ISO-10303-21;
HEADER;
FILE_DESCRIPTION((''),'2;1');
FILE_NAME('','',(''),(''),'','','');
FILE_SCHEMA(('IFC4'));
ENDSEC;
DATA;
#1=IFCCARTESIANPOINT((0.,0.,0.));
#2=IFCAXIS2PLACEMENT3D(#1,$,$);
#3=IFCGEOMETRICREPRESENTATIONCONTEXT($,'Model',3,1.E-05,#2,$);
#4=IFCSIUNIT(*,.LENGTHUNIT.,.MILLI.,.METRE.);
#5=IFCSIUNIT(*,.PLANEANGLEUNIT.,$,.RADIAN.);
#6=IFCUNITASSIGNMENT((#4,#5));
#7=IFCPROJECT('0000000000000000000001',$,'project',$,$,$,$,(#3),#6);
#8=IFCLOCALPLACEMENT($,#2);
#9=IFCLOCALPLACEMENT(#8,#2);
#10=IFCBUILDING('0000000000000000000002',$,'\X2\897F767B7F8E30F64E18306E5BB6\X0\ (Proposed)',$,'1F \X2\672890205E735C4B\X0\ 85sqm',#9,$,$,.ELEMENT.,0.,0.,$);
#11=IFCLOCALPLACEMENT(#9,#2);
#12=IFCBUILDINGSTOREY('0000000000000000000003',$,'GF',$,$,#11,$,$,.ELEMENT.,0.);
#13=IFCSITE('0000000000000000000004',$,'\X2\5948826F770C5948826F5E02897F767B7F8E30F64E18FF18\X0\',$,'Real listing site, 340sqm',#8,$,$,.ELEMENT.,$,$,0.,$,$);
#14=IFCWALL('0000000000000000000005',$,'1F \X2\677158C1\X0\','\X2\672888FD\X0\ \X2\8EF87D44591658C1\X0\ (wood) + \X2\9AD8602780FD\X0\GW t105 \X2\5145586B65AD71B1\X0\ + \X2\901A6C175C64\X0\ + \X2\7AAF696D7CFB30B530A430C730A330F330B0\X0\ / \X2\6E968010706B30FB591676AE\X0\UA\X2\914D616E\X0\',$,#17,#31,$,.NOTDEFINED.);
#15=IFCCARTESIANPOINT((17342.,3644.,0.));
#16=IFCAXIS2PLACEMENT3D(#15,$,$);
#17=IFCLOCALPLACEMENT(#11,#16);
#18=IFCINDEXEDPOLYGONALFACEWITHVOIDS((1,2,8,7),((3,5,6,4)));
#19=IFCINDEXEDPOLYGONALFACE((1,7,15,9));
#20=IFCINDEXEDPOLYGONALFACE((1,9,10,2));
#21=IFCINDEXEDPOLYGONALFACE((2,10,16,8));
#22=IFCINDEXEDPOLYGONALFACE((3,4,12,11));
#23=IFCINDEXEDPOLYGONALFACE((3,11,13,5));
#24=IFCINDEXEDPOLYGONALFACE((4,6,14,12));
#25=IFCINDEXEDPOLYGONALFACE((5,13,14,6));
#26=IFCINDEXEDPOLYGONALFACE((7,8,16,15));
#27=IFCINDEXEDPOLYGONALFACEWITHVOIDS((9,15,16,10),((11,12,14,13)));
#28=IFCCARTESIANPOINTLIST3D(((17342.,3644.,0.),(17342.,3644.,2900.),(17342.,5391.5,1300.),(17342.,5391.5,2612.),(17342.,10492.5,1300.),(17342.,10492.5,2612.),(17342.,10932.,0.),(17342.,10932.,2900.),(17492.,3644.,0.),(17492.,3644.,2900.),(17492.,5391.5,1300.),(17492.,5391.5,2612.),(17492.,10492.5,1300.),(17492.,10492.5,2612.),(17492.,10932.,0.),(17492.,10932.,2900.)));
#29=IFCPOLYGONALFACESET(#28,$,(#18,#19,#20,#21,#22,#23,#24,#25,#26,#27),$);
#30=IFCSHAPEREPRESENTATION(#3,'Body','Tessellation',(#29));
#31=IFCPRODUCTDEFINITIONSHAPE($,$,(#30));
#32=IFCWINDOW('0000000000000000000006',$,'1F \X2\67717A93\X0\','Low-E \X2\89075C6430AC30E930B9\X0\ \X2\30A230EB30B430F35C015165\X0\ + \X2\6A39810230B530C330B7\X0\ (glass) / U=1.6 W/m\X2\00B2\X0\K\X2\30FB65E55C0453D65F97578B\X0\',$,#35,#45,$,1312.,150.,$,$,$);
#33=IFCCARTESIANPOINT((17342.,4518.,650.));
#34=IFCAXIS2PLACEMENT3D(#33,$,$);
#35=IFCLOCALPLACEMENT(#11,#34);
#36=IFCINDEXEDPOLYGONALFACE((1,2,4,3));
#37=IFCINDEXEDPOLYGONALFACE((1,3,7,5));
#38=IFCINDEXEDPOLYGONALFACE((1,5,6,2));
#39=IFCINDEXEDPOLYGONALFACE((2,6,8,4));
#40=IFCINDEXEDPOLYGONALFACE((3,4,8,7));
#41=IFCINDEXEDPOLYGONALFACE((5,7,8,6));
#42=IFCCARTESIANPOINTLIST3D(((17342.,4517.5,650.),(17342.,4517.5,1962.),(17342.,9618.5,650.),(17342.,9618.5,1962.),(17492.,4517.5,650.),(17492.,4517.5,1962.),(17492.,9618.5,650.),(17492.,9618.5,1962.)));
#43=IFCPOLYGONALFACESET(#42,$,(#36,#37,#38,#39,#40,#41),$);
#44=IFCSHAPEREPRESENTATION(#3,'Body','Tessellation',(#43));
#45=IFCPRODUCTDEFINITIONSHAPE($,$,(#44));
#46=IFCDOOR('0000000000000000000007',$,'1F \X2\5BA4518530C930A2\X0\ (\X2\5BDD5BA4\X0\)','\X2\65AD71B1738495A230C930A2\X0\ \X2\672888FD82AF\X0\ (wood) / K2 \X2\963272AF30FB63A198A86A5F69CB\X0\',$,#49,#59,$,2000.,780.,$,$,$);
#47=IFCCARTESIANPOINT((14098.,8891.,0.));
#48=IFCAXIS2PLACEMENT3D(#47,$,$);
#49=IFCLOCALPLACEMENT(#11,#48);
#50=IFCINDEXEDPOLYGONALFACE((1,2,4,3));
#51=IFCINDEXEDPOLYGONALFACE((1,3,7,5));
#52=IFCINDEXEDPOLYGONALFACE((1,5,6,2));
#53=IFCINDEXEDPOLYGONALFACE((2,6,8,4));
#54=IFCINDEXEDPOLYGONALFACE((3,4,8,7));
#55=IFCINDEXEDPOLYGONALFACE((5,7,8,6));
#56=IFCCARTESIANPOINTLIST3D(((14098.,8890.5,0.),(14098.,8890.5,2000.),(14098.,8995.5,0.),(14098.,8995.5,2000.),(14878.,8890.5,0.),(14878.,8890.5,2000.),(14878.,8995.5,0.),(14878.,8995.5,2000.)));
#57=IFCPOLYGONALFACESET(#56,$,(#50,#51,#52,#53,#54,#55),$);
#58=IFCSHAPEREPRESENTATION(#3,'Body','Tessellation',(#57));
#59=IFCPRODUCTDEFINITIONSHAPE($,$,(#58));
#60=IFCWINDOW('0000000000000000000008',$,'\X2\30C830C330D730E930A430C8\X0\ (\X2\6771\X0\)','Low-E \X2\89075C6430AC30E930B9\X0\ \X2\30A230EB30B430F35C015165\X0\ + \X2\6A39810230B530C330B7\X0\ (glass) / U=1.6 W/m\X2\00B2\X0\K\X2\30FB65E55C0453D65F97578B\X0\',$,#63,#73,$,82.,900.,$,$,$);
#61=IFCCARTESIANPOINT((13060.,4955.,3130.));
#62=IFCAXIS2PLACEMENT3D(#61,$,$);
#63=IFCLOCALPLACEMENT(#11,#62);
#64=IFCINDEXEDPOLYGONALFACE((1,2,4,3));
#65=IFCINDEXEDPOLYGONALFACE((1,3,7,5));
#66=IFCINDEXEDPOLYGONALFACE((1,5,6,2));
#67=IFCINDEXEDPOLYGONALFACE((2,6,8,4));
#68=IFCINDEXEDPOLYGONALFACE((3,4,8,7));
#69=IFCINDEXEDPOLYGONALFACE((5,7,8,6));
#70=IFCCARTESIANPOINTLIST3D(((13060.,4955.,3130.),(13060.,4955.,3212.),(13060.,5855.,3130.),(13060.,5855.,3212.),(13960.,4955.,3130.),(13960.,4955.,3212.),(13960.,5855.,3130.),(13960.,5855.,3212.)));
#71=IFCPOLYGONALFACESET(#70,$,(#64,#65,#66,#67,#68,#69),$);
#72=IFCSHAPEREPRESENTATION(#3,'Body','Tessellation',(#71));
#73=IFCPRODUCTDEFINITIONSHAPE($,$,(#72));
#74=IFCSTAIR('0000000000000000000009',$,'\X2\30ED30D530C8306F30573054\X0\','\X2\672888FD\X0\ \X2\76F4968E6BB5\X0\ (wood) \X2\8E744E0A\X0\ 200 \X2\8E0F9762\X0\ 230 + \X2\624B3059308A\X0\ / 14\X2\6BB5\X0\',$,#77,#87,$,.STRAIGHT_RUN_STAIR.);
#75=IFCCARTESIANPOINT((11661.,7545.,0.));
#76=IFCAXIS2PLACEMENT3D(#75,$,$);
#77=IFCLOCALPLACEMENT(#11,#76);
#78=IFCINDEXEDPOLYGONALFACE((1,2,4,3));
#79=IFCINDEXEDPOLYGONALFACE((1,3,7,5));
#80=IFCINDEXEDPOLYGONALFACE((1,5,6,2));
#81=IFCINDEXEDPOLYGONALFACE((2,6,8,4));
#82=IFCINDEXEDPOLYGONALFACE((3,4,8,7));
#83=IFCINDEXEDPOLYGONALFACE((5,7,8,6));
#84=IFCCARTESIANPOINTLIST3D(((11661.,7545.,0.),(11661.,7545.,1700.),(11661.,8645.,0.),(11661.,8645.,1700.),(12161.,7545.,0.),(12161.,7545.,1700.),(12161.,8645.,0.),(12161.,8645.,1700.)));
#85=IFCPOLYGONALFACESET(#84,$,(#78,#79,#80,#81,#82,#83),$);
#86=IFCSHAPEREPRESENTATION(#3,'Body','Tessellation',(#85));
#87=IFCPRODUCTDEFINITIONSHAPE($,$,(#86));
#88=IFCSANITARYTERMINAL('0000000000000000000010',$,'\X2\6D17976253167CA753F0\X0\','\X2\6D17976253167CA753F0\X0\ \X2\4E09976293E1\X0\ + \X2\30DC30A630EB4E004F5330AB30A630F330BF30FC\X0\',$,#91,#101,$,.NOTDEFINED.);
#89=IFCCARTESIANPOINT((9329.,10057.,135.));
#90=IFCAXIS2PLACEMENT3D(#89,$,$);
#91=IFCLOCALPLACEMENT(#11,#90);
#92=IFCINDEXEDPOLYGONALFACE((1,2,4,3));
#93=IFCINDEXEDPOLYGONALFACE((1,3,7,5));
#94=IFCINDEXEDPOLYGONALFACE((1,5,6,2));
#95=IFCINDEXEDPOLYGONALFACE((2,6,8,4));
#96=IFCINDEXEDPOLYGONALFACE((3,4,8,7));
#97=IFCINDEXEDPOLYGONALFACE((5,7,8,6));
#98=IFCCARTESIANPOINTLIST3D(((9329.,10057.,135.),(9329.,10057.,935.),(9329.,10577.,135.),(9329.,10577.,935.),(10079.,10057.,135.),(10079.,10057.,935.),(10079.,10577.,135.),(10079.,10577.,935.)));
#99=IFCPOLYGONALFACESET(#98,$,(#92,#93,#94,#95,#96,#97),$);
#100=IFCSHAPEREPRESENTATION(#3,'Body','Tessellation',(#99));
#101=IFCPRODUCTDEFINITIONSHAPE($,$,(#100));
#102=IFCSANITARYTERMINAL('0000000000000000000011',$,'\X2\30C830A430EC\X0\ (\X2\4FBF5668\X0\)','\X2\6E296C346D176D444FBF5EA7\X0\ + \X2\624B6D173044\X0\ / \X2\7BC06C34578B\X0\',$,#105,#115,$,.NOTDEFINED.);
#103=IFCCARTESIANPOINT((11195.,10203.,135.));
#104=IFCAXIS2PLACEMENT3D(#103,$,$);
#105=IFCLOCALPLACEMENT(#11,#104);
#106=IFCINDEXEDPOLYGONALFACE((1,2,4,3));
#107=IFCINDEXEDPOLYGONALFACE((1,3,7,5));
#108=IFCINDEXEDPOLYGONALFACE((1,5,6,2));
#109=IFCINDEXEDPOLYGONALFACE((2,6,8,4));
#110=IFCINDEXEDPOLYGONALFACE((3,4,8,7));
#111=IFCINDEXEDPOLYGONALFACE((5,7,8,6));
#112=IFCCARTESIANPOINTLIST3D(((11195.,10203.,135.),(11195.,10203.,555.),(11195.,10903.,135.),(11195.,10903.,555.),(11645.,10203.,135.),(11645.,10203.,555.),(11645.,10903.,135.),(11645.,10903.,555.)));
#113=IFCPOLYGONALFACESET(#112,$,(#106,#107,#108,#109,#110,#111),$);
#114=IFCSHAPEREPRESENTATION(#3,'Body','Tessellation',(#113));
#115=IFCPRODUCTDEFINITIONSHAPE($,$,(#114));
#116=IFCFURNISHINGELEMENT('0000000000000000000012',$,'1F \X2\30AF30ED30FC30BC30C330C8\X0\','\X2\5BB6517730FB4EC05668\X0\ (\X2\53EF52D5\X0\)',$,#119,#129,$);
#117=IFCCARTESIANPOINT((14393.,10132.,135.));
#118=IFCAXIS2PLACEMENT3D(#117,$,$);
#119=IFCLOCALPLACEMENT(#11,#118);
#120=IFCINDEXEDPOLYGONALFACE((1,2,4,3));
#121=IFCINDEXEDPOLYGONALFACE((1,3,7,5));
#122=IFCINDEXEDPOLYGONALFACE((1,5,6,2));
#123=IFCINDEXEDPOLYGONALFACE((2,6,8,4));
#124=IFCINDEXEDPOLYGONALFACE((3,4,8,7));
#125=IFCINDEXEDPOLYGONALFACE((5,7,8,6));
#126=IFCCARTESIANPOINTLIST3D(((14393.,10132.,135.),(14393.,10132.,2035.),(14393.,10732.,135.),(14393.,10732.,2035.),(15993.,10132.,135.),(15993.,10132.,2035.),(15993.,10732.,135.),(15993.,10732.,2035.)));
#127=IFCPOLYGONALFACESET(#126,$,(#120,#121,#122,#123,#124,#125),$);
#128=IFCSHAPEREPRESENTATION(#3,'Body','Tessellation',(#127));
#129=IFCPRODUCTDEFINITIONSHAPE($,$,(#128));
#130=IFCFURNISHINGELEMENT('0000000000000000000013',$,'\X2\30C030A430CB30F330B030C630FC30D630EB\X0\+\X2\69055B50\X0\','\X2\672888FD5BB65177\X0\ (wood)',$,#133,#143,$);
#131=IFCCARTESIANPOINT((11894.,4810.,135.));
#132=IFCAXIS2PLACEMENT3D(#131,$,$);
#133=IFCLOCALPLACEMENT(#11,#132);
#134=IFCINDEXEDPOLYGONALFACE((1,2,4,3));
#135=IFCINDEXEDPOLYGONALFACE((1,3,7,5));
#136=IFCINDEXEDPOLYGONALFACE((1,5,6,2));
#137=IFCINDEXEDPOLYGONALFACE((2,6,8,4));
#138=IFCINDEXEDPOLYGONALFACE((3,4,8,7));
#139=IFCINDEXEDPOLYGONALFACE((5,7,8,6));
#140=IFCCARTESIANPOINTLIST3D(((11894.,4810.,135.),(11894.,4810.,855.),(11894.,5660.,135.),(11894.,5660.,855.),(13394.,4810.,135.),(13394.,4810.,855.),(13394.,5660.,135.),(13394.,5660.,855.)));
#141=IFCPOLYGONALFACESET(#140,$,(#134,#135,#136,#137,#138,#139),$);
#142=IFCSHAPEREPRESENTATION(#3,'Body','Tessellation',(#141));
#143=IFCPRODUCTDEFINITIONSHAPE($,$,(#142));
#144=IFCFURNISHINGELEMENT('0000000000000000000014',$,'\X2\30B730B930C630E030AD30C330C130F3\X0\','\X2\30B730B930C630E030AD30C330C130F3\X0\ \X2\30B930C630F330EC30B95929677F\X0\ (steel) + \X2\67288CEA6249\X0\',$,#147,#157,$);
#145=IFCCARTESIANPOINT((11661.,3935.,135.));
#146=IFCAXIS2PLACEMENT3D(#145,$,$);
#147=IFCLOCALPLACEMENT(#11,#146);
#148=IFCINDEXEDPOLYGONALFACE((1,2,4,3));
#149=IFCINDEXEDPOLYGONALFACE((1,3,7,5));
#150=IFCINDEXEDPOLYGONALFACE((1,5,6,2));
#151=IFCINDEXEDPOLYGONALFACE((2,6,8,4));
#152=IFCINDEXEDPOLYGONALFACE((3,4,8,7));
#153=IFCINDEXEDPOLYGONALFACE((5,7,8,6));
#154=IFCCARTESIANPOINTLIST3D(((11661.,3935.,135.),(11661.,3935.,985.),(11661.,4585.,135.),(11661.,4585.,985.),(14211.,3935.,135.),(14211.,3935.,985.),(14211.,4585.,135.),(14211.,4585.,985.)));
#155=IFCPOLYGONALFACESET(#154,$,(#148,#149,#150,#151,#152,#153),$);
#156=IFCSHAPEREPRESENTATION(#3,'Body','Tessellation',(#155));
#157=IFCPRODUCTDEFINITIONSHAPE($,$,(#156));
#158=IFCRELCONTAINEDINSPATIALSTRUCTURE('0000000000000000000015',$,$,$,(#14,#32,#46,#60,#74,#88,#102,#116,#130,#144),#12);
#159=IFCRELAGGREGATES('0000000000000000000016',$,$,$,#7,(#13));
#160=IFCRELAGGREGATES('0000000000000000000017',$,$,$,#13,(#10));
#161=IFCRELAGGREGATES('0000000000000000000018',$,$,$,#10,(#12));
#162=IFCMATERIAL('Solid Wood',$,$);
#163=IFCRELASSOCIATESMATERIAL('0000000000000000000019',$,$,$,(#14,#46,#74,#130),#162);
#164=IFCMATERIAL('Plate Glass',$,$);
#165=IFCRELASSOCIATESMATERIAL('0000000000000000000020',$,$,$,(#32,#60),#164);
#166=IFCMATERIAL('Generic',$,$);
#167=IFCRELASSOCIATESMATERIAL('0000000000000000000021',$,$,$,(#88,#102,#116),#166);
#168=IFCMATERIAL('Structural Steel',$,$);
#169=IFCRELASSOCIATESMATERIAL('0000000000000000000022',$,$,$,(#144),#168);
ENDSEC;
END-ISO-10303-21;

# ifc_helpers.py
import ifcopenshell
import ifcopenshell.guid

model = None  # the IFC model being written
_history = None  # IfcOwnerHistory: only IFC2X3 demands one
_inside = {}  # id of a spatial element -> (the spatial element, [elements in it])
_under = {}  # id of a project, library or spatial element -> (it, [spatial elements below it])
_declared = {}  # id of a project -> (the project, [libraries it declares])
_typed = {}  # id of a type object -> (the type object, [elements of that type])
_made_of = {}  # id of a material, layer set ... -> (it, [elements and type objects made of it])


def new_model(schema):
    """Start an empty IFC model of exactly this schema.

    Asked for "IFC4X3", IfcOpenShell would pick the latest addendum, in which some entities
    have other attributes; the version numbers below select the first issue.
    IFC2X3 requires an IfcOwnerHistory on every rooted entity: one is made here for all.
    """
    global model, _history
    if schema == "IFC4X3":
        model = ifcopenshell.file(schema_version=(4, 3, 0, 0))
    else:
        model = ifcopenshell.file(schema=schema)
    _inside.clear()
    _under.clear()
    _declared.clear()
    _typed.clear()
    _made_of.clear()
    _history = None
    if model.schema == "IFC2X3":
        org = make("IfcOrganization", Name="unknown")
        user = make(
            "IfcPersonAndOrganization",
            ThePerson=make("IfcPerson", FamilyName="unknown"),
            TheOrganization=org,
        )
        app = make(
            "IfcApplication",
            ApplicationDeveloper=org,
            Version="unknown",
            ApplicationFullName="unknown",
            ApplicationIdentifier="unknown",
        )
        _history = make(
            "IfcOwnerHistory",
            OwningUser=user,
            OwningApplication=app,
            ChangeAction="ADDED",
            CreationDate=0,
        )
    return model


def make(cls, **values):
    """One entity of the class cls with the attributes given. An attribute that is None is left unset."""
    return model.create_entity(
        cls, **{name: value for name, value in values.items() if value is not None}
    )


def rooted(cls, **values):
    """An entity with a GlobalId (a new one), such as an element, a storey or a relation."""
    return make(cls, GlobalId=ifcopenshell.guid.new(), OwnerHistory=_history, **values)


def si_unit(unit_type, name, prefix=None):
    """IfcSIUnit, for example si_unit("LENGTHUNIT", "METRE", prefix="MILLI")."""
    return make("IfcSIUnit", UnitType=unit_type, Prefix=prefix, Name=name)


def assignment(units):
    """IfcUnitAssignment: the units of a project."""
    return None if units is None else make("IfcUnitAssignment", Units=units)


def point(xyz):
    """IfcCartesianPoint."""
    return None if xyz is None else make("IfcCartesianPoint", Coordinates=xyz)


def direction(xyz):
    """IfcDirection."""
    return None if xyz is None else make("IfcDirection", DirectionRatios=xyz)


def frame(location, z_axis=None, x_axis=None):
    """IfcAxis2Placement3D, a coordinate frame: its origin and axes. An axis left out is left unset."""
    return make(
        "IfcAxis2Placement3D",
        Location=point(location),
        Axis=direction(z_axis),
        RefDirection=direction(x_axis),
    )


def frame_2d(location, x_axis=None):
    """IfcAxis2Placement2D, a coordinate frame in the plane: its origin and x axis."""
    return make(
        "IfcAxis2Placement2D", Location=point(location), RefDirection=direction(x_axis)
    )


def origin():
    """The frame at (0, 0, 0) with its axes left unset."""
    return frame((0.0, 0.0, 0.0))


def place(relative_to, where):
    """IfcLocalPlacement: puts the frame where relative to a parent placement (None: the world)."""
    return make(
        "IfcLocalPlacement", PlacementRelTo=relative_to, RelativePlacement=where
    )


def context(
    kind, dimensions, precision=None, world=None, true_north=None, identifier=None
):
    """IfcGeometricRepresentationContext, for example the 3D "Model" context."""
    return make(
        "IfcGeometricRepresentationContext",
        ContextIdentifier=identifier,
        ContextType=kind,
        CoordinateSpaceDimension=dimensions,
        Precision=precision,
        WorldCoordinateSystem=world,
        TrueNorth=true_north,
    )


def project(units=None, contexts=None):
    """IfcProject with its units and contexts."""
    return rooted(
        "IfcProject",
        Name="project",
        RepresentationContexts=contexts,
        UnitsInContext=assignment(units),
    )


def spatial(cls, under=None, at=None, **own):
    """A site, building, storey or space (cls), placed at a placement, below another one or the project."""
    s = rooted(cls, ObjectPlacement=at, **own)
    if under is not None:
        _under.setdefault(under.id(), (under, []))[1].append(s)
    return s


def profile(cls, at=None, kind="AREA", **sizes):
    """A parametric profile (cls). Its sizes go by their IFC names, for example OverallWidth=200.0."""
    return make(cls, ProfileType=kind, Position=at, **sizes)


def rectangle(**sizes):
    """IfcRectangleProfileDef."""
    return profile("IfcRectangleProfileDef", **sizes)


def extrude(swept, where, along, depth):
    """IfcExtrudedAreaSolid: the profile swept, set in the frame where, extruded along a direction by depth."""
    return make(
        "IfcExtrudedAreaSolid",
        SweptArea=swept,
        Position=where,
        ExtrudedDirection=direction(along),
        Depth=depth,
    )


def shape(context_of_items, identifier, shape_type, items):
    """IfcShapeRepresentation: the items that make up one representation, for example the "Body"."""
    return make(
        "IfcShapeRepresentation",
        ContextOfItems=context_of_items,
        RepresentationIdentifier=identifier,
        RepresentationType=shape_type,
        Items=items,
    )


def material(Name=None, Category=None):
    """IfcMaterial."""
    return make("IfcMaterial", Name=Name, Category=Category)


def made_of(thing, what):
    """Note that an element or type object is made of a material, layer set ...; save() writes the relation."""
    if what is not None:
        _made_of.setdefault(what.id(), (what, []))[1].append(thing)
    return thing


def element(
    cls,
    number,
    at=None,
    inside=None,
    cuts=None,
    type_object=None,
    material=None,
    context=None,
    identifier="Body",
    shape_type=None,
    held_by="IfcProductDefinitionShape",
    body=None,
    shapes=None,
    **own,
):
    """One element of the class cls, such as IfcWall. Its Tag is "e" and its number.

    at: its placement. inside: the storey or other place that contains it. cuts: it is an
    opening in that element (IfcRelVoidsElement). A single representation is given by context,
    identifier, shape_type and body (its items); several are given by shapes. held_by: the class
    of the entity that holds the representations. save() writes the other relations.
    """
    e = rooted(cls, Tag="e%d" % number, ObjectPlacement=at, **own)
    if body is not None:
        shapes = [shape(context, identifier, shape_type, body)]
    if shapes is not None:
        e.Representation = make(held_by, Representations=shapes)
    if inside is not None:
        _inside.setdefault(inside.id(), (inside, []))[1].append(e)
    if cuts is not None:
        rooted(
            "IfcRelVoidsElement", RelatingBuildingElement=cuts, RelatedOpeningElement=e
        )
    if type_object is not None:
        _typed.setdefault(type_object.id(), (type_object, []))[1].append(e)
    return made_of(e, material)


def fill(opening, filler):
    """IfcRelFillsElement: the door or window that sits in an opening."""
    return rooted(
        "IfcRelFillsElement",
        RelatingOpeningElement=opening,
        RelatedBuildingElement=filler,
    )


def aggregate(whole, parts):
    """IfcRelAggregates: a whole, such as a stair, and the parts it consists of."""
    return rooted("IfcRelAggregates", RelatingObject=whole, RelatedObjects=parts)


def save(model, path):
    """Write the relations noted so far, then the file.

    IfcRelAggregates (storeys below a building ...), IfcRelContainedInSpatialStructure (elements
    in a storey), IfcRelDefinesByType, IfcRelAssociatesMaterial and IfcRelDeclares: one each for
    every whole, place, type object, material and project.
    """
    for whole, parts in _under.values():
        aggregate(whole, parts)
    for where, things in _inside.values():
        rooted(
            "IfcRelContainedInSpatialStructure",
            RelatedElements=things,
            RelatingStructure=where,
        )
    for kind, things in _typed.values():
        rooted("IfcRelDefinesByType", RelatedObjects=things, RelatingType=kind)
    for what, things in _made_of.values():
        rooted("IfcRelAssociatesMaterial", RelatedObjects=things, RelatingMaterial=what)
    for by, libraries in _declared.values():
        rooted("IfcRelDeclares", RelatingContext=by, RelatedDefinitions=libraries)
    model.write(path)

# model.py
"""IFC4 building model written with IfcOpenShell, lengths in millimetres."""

from ifc_helpers import new_model, si_unit, frame, frame_2d, origin, place, context, project, spatial, rectangle, extrude, material, element, fill, save


model = new_model("IFC4")

# Units and contexts
model_context = context("Model", 3, precision=1e-05, world=origin())
ifc_project = project(units=[si_unit("LENGTHUNIT", "METRE", prefix="MILLI"), si_unit("PLANEANGLEUNIT", "RADIAN")], contexts=[model_context])

# Site, building, storey
site_placement = place(None, origin())
site = spatial("IfcSite", under=ifc_project, at=site_placement, Name="奈良県奈良市西登美ヶ丘８", ObjectType="Real listing site, 340sqm", CompositionType="ELEMENT", RefElevation=0.0)
building_placement = place(site_placement, origin())
building = spatial("IfcBuilding", under=site, at=building_placement, Name="西登美ヶ丘の家 (Proposed)", ObjectType="1F 木造平屋 85sqm", CompositionType="ELEMENT", ElevationOfRefHeight=0.0, ElevationOfTerrain=0.0)
storey_placement = place(building_placement, origin())
storey = spatial("IfcBuildingStorey", under=building, at=storey_placement, Name="GF", CompositionType="ELEMENT", Elevation=0.0)

# Shared definitions
ifc_material_1 = material(Name="Solid Wood")

# Wall, opening, window
wall_1_placement = place(storey_placement, frame((17342.0, 3644.0, 0.0)))
wall_1 = element("IfcWall", 1, at=wall_1_placement, inside=storey, material=ifc_material_1, Name="1F 東壁", Description="木製 軸組外壁 (wood) + 高性能GW t105 充填断熱 + 通気層 + 窯業系サイディング / 準耐火・外皮UA配慮", PredefinedType="NOTDEFINED", context=model_context, shape_type="SweptSolid", body=[
    extrude(rectangle(XDim=150.0, YDim=7288.0, at=frame_2d((75.0, 3644.0))), frame((17342.0, 3644.0, 0.0)), (0.0, 0.0, 1.0), 2900.0),
])
opening_1_placement = place(storey_placement, frame((17342.0, 4518.0, 650.0)))
opening_1 = element("IfcOpeningElement", 2, at=opening_1_placement, cuts=wall_1, PredefinedType="NOTDEFINED", context=model_context, shape_type="SweptSolid", body=[
    extrude(rectangle(XDim=150.0, YDim=5101.0, at=frame_2d((75.0, 2550.0))), frame((17342.0, 4518.0, 650.0)), (0.0, 0.0, 1.0), 1312.0),
])
ifc_material_2 = material(Name="Plate Glass")
window_1_placement = place(storey_placement, frame((17342.0, 4518.0, 650.0)))
window_1 = element("IfcWindow", 3, at=window_1_placement, inside=storey, material=ifc_material_2, Name="1F 東窓", Description="Low-E 複層ガラス アルゴン封入 + 樹脂サッシ (glass) / U=1.6 W/m²K・日射取得型", OverallHeight=1312.0, OverallWidth=150.0, context=model_context, shape_type="SweptSolid", body=[
    extrude(rectangle(XDim=150.0, YDim=5101.0, at=frame_2d((75.0, 2550.0))), frame((17342.0, 4518.0, 650.0)), (0.0, 0.0, 1.0), 1312.0),
])
fill(opening_1, window_1)

# Door
door_placement = place(storey_placement, frame((14098.0, 8891.0, 0.0)))
element("IfcDoor", 4, at=door_placement, inside=storey, material=ifc_material_1, Name="1F 室内ドア (寝室)", Description="断熱玄関ドア 木製芯 (wood) / K2 防犯・採風機構", OverallHeight=2000.0, OverallWidth=780.0, context=model_context, shape_type="SweptSolid", body=[
    extrude(rectangle(XDim=780.0, YDim=105.0, at=frame_2d((390.0, 52.0))), frame((14098.0, 8891.0, 0.0)), (0.0, 0.0, 1.0), 2000.0),
])

# Window
window_2_placement = place(storey_placement, frame((13060.0, 4955.0, 3130.0)))
element("IfcWindow", 5, at=window_2_placement, inside=storey, material=ifc_material_2, Name="トップライト (東)", Description="Low-E 複層ガラス アルゴン封入 + 樹脂サッシ (glass) / U=1.6 W/m²K・日射取得型", OverallHeight=82.0, OverallWidth=900.0, context=model_context, shape_type="SweptSolid", body=[
    extrude(rectangle(XDim=900.0, YDim=900.0, at=frame_2d((450.0, 450.0))), frame((13060.0, 4955.0, 3130.0)), (0.0, 0.0, 1.0), 82.0),
])

# Stair
stair_placement = place(storey_placement, frame((11661.0, 7545.0, 0.0)))
element("IfcStair", 6, at=stair_placement, inside=storey, material=ifc_material_1, Name="ロフトはしご", Description="木製 直階段 (wood) 蹴上 200 踏面 230 + 手すり / 14段", PredefinedType="STRAIGHT_RUN_STAIR", context=model_context, shape_type="SweptSolid", body=[
    extrude(rectangle(XDim=500.0, YDim=1100.0, at=frame_2d((250.0, 550.0))), frame((11661.0, 7545.0, 0.0)), (0.0, 0.0, 1.0), 1700.0),
])

# Shared definitions
ifc_material_3 = material(Name="Structural Steel")

# Shared definitions
ifc_material_4 = material(Name="Generic")

# Sanitary terminals
sanitary_terminal_1_placement = place(storey_placement, frame((9329.0, 10057.0, 135.0)))
element("IfcSanitaryTerminal", 7, at=sanitary_terminal_1_placement, inside=storey, material=ifc_material_4, Name="洗面化粧台", Description="洗面化粧台 三面鏡 + ボウル一体カウンター", PredefinedType="NOTDEFINED", context=model_context, shape_type="SweptSolid", body=[
    extrude(rectangle(XDim=750.0, YDim=520.0, at=frame_2d((375.0, 260.0))), frame((9329.0, 10057.0, 135.0)), (0.0, 0.0, 1.0), 800.0),
])
sanitary_terminal_2_placement = place(storey_placement, frame((11195.0, 10203.0, 135.0)))
element("IfcSanitaryTerminal", 8, at=sanitary_terminal_2_placement, inside=storey, material=ifc_material_4, Name="トイレ (便器)", Description="温水洗浄便座 + 手洗い / 節水型", PredefinedType="NOTDEFINED", context=model_context, shape_type="SweptSolid", body=[
    extrude(rectangle(XDim=450.0, YDim=700.0, at=frame_2d((225.0, 350.0))), frame((11195.0, 10203.0, 135.0)), (0.0, 0.0, 1.0), 420.0),
])

# Furnishing elements
furnishing_1_placement = place(storey_placement, frame((14393.0, 10132.0, 135.0)))
element("IfcFurnishingElement", 9, at=furnishing_1_placement, inside=storey, material=ifc_material_4, Name="1F クローゼット", Description="家具・什器 (可動)", context=model_context, shape_type="SweptSolid", body=[
    extrude(rectangle(XDim=1600.0, YDim=600.0, at=frame_2d((800.0, 300.0))), frame((14393.0, 10132.0, 135.0)), (0.0, 0.0, 1.0), 1900.0),
])
furnishing_2_placement = place(storey_placement, frame((11894.0, 4810.0, 135.0)))
element("IfcFurnishingElement", 10, at=furnishing_2_placement, inside=storey, material=ifc_material_1, Name="ダイニングテーブル+椅子", Description="木製家具 (wood)", context=model_context, shape_type="SweptSolid", body=[
    extrude(rectangle(XDim=1500.0, YDim=850.0, at=frame_2d((750.0, 425.0))), frame((11894.0, 4810.0, 135.0)), (0.0, 0.0, 1.0), 720.0),
])
furnishing_3_placement = place(storey_placement, frame((11661.0, 3935.0, 135.0)))
element("IfcFurnishingElement", 11, at=furnishing_3_placement, inside=storey, material=ifc_material_3, Name="システムキッチン", Description="システムキッチン ステンレス天板 (steel) + 木質扉", context=model_context, shape_type="SweptSolid", body=[
    extrude(rectangle(XDim=2550.0, YDim=650.0, at=frame_2d((1275.0, 325.0))), frame((11661.0, 3935.0, 135.0)), (0.0, 0.0, 1.0), 850.0),
])

save(model, "model.ifc")
